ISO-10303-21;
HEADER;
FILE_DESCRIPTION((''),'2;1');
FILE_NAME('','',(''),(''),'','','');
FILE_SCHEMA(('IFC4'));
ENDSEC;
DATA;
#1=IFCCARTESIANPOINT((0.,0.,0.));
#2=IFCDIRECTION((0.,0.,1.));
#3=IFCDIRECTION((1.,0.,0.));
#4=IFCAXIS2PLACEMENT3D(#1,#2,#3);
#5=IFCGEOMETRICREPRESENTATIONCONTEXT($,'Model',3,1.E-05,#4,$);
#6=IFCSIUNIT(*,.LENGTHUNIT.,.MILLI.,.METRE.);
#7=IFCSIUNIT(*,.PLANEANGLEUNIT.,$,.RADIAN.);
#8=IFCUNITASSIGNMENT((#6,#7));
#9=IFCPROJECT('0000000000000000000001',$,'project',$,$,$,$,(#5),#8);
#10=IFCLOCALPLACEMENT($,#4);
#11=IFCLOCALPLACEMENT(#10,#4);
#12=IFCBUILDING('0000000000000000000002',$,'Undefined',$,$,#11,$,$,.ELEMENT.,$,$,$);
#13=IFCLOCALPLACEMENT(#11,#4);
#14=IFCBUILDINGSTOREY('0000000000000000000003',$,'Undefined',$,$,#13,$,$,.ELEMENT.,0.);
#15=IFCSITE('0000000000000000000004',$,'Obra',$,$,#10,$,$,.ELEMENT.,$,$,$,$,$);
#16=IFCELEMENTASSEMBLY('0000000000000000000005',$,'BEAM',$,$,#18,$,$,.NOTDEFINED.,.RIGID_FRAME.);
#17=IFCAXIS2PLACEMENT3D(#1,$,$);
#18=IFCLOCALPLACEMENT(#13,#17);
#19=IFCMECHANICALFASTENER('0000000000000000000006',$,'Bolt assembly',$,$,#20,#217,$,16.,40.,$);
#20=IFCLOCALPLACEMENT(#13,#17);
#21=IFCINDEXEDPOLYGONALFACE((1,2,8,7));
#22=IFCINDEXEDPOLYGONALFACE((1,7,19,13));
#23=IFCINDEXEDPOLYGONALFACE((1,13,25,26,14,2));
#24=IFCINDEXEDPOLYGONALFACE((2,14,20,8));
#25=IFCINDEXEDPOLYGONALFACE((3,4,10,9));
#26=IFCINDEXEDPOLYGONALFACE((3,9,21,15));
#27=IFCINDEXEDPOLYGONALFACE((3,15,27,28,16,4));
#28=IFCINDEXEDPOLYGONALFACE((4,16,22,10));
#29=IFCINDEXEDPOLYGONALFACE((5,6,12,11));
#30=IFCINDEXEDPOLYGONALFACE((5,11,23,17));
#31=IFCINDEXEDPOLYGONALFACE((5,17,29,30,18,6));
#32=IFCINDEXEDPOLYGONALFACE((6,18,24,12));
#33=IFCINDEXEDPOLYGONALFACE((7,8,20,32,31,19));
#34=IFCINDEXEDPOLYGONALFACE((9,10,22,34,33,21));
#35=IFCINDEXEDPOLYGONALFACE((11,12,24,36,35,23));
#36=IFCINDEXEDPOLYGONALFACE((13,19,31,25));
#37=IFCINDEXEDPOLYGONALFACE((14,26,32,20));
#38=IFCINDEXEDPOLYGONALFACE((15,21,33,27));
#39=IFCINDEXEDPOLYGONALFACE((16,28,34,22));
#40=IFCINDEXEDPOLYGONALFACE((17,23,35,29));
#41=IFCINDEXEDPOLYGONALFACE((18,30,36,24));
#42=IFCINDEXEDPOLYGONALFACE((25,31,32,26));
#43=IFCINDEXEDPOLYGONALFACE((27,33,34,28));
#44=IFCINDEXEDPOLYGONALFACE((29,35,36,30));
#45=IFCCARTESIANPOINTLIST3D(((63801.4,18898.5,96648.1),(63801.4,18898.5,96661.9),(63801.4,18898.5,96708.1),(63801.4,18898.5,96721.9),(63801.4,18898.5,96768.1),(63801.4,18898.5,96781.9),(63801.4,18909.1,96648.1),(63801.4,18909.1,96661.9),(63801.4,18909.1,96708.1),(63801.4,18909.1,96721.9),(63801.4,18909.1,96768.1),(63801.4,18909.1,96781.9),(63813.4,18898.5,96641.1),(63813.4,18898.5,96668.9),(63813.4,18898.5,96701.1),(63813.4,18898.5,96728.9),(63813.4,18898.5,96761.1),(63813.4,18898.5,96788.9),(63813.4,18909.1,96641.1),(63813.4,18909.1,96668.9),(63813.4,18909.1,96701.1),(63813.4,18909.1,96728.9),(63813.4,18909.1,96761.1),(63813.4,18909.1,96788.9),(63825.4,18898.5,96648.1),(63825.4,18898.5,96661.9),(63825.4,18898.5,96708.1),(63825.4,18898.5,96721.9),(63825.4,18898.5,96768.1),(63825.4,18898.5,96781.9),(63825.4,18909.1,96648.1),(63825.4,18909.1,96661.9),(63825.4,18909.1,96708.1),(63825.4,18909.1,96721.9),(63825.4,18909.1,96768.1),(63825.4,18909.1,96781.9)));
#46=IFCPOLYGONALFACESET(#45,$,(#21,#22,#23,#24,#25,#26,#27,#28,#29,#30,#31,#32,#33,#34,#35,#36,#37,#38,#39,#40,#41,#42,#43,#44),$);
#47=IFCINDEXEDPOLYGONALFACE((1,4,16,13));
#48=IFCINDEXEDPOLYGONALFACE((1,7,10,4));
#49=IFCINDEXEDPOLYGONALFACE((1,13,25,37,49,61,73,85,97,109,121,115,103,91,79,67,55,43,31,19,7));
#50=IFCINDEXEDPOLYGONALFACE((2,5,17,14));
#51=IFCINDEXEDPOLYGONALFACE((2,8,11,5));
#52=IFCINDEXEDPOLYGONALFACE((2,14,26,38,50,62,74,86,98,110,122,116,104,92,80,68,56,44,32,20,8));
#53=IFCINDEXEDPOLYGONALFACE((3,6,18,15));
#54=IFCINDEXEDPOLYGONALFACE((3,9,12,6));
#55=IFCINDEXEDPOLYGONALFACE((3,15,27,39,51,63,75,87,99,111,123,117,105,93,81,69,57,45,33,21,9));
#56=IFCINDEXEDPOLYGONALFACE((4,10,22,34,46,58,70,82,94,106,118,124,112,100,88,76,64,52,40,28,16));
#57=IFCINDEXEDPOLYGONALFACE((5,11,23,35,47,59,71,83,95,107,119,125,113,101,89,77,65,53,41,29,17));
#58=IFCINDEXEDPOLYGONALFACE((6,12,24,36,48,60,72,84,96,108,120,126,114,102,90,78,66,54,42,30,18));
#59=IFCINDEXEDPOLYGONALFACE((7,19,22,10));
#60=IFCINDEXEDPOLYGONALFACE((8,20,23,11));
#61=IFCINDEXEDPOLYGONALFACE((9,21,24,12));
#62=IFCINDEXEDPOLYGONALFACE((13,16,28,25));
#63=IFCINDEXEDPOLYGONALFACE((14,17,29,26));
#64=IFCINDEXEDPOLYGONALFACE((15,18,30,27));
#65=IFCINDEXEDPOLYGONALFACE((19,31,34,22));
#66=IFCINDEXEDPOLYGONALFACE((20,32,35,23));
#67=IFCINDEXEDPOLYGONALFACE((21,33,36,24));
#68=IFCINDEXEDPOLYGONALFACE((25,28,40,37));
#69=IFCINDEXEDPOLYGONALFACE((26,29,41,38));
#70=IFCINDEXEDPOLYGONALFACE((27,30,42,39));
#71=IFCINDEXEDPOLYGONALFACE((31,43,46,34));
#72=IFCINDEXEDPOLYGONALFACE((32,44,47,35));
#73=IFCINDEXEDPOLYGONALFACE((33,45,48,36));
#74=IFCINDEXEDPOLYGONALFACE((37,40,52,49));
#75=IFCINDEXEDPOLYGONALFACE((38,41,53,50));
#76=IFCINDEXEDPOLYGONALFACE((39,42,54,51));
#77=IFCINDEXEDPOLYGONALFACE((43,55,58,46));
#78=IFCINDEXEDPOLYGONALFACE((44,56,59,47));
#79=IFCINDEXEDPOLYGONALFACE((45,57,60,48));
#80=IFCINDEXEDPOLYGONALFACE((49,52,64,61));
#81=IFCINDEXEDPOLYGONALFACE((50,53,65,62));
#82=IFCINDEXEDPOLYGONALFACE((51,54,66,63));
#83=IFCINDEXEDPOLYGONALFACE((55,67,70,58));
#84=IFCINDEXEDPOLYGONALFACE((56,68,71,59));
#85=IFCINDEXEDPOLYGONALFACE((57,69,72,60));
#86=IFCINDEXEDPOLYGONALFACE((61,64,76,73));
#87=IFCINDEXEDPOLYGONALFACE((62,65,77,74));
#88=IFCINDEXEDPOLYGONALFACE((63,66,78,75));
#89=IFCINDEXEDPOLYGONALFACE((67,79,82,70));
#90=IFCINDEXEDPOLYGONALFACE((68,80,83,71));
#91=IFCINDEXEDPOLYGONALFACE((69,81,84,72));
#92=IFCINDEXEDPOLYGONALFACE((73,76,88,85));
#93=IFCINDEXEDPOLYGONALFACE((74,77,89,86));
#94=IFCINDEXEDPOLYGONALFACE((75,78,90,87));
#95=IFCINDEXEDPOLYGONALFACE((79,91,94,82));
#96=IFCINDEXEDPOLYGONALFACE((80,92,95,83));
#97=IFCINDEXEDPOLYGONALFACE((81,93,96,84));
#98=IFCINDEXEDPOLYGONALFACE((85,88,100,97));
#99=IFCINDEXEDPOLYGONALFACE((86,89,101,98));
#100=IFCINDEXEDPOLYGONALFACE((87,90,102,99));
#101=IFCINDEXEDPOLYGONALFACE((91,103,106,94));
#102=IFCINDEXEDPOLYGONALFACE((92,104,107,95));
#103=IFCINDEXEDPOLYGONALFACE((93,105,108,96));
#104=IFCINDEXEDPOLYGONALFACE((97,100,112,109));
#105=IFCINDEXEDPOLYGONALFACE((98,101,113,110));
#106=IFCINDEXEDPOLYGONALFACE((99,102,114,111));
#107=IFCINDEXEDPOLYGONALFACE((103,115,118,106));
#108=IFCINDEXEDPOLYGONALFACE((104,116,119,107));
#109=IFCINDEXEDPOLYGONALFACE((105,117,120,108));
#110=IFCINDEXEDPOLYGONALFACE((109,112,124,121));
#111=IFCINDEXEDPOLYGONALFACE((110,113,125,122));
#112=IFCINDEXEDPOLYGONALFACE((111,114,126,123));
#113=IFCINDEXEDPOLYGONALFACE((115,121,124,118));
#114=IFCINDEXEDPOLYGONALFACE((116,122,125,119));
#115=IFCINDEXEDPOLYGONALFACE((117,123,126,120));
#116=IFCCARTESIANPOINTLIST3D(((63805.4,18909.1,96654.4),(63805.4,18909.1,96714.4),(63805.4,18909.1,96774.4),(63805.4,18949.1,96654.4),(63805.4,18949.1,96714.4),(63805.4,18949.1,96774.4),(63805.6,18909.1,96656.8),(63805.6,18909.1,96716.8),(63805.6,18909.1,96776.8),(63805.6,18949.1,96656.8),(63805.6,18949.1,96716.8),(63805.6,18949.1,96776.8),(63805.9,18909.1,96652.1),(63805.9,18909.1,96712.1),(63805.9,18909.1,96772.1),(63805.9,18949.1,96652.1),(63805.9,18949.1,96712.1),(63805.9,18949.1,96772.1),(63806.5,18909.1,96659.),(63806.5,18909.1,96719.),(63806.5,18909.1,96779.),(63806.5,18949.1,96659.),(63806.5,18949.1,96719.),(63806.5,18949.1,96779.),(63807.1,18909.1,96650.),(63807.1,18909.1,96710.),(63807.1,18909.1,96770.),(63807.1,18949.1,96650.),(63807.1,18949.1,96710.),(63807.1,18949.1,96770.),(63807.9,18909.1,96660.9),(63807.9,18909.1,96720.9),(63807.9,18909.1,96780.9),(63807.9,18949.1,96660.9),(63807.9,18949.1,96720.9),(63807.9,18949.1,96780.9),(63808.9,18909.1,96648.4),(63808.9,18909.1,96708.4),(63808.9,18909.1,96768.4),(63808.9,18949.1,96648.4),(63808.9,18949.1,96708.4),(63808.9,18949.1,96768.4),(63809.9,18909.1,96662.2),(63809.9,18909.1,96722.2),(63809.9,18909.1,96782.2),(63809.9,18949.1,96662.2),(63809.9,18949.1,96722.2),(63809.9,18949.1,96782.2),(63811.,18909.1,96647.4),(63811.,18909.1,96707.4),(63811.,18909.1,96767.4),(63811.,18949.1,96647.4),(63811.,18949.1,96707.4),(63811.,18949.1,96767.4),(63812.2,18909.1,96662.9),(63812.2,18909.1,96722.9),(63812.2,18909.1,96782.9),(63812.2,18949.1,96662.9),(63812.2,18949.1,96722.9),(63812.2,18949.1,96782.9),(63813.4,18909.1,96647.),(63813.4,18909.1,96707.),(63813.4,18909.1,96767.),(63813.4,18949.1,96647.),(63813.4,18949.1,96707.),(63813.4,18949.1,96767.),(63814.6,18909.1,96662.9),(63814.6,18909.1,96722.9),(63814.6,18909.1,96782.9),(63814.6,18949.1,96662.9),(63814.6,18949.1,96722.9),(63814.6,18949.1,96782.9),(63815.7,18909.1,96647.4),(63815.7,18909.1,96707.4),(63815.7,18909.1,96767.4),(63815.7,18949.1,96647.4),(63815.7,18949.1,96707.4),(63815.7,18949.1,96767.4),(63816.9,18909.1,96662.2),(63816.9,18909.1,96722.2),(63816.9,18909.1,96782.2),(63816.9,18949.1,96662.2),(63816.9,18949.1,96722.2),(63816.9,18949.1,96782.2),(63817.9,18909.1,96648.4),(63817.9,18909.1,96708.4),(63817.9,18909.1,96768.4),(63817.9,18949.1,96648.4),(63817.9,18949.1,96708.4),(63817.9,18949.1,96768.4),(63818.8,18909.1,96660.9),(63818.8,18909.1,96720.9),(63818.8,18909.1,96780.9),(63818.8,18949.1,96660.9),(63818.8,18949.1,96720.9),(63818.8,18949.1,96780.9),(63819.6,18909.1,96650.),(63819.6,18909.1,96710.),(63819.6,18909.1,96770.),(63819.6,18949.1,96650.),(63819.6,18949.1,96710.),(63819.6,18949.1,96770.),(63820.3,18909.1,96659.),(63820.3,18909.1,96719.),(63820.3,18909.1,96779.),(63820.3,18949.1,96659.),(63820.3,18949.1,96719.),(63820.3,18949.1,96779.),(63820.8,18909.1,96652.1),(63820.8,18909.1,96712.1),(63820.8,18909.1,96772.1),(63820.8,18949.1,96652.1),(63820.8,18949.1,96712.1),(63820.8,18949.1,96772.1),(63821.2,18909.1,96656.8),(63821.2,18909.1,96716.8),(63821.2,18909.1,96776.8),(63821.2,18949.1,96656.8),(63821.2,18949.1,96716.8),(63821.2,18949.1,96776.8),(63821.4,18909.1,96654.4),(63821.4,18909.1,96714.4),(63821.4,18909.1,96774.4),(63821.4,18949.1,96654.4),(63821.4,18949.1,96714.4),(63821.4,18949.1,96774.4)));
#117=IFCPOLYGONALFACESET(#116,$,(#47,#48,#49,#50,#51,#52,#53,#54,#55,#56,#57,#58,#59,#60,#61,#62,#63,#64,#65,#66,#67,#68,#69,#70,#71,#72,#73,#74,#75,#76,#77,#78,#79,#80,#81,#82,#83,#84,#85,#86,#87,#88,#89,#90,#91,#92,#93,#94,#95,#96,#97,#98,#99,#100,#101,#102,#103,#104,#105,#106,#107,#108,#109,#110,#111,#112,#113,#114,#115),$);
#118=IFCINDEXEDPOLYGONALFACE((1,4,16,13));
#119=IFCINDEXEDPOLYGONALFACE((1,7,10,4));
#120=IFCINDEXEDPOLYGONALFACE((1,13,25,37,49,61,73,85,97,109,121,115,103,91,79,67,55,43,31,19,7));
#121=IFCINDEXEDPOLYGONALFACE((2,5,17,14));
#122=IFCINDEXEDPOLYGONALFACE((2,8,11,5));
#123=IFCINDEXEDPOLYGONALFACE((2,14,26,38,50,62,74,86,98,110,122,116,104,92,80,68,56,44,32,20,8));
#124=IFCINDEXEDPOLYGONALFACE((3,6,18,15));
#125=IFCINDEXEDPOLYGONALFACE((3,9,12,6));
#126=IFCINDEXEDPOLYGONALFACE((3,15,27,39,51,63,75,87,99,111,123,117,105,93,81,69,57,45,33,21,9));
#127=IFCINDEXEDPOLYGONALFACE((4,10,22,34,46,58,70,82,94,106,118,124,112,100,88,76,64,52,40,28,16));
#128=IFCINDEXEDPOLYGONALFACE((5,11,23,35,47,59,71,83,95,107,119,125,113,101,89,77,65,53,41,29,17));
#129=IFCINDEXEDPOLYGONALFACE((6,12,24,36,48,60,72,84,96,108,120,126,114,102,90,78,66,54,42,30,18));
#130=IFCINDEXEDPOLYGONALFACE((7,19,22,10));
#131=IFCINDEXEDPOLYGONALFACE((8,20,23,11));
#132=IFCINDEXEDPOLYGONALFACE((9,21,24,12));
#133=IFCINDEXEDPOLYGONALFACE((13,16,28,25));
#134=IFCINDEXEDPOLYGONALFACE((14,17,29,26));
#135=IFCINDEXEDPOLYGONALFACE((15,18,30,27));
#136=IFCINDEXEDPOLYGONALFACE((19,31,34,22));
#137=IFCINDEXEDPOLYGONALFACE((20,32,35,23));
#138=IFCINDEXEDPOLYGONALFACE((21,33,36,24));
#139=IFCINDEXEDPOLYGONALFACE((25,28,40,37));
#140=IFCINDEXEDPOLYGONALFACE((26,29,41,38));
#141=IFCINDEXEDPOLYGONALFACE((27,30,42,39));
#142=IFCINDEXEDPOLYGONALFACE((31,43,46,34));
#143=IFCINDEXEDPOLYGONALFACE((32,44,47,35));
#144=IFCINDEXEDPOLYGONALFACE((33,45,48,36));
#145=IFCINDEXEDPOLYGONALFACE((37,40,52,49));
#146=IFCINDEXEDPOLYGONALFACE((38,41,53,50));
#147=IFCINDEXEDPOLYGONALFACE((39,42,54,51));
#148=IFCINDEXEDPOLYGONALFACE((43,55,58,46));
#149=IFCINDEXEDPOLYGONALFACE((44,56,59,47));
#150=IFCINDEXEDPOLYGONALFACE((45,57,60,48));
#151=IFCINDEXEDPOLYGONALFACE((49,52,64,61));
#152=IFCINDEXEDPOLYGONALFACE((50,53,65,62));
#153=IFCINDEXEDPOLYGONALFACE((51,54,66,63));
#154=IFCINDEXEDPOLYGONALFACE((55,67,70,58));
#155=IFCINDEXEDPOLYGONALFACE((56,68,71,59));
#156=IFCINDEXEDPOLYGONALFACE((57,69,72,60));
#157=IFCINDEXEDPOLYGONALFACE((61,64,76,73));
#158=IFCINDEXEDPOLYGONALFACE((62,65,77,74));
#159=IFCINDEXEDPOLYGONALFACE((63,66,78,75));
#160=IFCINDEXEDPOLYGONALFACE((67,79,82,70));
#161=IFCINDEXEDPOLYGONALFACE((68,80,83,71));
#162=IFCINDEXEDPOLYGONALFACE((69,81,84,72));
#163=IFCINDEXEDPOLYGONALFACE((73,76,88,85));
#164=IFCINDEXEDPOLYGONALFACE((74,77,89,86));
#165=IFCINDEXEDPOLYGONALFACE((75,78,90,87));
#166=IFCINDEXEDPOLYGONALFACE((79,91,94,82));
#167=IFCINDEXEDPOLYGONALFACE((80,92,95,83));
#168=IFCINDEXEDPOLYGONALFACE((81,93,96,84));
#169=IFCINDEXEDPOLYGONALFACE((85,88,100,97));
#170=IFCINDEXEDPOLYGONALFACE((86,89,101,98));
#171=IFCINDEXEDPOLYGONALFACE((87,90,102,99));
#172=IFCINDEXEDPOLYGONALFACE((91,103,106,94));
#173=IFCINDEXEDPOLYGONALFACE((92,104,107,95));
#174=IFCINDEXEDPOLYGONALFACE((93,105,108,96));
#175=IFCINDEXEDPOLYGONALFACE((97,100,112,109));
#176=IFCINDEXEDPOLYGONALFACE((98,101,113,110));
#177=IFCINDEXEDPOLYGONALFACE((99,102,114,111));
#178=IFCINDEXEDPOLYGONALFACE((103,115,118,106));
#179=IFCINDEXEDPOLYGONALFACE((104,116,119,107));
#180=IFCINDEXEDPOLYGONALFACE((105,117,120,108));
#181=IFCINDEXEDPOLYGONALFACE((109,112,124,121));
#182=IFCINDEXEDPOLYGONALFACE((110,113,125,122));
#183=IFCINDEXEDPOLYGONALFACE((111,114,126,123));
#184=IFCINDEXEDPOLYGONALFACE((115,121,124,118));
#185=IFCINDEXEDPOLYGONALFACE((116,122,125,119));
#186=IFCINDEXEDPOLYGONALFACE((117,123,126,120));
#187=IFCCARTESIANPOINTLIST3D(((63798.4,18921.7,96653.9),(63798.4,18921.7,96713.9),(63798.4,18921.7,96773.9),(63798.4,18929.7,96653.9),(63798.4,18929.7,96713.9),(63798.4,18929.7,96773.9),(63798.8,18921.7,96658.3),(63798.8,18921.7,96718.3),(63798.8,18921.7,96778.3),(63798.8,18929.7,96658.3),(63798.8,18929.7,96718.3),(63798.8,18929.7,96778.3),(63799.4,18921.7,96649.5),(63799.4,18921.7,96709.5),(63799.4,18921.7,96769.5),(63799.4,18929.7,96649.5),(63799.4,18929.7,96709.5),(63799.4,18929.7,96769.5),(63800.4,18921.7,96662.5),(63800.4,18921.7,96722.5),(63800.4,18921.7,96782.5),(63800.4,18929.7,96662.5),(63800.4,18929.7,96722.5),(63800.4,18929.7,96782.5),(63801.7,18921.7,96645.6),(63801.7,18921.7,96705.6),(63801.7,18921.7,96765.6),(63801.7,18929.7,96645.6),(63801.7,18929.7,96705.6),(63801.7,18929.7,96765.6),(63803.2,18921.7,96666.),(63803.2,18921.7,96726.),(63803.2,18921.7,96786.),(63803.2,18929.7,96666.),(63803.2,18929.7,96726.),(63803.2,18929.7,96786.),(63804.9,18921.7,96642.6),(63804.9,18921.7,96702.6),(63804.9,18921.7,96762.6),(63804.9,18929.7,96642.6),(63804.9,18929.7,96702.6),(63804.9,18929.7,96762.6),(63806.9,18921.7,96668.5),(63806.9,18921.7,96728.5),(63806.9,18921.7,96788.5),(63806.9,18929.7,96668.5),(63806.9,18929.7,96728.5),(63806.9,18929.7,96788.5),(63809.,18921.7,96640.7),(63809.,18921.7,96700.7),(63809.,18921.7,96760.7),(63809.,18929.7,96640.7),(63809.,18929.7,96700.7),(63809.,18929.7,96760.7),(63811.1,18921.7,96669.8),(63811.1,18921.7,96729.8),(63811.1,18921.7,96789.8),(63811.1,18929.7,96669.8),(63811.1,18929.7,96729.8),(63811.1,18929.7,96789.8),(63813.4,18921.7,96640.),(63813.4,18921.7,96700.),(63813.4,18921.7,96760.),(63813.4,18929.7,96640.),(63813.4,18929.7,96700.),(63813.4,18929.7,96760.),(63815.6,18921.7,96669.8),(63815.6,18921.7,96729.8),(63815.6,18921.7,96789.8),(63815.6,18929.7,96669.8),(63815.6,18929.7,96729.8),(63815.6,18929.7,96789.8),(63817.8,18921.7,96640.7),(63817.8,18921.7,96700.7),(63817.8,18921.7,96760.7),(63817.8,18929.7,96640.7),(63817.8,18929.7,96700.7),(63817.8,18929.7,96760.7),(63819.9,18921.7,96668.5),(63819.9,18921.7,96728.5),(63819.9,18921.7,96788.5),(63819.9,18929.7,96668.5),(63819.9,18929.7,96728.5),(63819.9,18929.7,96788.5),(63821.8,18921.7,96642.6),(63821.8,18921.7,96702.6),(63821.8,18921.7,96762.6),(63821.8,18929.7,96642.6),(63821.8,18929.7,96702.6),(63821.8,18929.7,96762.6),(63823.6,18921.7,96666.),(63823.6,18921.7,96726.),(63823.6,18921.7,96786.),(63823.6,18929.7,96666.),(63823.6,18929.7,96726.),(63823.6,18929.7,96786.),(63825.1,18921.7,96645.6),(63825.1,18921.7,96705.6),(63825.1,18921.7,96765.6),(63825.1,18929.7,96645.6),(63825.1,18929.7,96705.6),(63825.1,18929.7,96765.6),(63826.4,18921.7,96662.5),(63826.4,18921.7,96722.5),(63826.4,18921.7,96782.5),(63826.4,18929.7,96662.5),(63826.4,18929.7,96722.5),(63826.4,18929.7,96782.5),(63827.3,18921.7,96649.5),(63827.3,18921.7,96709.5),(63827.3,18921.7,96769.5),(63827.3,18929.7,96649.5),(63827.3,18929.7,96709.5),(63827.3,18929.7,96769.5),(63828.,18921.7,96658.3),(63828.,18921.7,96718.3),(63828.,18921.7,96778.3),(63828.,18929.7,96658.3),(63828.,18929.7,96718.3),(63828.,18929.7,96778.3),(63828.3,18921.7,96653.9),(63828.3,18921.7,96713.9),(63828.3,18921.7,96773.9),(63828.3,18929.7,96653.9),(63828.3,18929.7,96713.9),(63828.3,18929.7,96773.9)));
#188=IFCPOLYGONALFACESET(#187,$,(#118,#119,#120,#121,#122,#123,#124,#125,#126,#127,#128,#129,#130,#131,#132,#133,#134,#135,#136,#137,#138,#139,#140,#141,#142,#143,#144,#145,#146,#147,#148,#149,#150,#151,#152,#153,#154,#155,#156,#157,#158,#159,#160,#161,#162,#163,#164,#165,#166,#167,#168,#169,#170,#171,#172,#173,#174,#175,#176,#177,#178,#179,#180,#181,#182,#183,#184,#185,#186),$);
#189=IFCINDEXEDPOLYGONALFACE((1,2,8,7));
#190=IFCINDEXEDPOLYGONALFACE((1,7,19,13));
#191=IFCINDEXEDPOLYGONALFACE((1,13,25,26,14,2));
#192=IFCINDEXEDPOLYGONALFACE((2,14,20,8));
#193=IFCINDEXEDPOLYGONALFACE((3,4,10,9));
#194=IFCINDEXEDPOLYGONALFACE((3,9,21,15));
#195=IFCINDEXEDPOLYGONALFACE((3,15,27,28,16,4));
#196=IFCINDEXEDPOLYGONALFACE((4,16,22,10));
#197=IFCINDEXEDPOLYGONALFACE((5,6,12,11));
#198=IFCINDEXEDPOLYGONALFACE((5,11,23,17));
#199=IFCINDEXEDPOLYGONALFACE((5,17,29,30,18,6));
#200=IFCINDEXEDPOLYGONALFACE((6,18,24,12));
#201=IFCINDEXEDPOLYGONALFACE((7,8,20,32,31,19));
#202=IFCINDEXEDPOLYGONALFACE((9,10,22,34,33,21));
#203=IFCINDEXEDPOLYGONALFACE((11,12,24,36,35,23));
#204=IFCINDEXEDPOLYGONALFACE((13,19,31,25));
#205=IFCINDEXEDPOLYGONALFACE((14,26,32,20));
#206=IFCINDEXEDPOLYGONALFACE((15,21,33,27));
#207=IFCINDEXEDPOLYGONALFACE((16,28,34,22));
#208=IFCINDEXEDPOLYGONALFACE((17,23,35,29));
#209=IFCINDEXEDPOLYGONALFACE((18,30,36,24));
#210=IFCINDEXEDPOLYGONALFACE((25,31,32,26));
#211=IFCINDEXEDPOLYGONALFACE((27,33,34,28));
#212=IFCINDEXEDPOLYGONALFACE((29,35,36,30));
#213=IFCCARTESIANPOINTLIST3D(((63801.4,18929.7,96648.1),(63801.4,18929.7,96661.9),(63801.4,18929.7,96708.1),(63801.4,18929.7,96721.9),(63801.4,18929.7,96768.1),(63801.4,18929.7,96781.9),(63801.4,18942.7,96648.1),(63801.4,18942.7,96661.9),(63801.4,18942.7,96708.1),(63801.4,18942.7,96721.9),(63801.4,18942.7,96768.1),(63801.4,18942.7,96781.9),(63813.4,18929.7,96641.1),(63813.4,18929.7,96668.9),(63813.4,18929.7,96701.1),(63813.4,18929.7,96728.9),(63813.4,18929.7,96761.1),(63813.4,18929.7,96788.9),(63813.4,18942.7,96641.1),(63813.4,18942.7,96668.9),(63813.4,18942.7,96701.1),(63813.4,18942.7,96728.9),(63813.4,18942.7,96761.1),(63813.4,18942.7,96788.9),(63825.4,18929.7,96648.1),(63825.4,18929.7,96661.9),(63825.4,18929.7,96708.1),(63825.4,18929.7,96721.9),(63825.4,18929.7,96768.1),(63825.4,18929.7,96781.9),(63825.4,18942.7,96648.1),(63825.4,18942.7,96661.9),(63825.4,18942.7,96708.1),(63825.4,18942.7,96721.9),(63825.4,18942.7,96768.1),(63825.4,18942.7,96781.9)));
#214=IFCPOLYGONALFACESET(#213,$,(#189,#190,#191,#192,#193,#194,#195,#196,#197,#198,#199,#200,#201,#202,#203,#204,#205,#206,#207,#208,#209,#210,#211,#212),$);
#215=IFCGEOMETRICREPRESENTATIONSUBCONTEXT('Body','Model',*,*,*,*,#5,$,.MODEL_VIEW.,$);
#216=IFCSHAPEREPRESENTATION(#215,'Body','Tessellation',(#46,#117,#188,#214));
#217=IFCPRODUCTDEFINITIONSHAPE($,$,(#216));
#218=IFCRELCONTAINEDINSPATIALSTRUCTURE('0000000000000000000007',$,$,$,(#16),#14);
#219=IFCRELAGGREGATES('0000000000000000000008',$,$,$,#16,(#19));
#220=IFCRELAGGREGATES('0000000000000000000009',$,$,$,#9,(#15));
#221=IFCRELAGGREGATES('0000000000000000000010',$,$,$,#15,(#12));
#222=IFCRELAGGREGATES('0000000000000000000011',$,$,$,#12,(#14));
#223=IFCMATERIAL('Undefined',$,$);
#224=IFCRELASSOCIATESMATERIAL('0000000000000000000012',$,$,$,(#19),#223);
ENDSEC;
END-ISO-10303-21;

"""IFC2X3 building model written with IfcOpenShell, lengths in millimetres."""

from ifc_helpers import new_model, si_unit, frame, origin_with_axes, origin_2d_with_axis, place, context, subcontext, project, spatial, polyline, circle, outline, extrude, source, transform, mapped, material, element, aggregate, save


model = new_model("IFC2X3")

# Units and contexts
model_context = context("Model", 3, precision=1e-05, world=origin_with_axes())
body_context = subcontext(model_context, "Body", "Model", "MODEL_VIEW")
ifc_project = project(units=[si_unit("LENGTHUNIT", "METRE", prefix="MILLI"), si_unit("PLANEANGLEUNIT", "RADIAN")], contexts=[model_context])

# Site, building, storey
site_placement = place(None, origin_with_axes())
site = spatial("IfcSite", under=ifc_project, at=site_placement, Name="Obra", CompositionType="ELEMENT")
building_placement = place(site_placement, origin_with_axes())
building = spatial("IfcBuilding", under=site, at=building_placement, Name="Undefined", CompositionType="ELEMENT")
storey_placement = place(building_placement, origin_with_axes())
storey = spatial("IfcBuildingStorey", under=building, at=storey_placement, Name="Undefined", CompositionType="ELEMENT", Elevation=0.0)

# Shared definitions
ifc_material_1 = material(Name="Undefined")

# Element assembly, mechanical fastener
assembly_1_placement = place(storey_placement, origin_with_axes())
assembly_1 = element("IfcElementAssembly", 1, at=assembly_1_placement, inside=storey, Name="BEAM", AssemblyPlace="NOTDEFINED", PredefinedType="RIGID_FRAME")
shared_shape_1 = source(origin_with_axes(), body_context, "Body", "SweptSolid", [
    extrude(outline(polyline([(13.9, 0.0), (6.9, 12.0), (-6.9, 12.0), (-13.9, 0.0), (-6.9, -12.0), (6.9, -12.0), (13.9, 0.0)])), frame((0.0, -19.9, 0.0), z_axis=(0.0, 1.0, 0.0), x_axis=(1.0, 0.0, 0.0)), (0.0, 0.0, 1.0), 10.6),
    extrude(circle(Radius=8.0, at=origin_2d_with_axis()), frame((0.0, -9.3, 0.0), z_axis=(0.0, 1.0, 0.0), x_axis=(1.0, 0.0, 0.0)), (0.0, 0.0, 1.0), 40.0),
    extrude(circle(Radius=15.0, at=origin_2d_with_axis()), frame((0.0, 3.3, 0.0), z_axis=(0.0, 1.0, 0.0), x_axis=(1.0, 0.0, 0.0)), (0.0, 0.0, 1.0), 8.0),
    extrude(outline(polyline([(13.9, 0.0), (6.9, 12.0), (-6.9, 12.0), (-13.9, 0.0), (-6.9, -12.0), (6.9, -12.0), (13.9, 0.0)])), frame((0.0, 11.3, 0.0), z_axis=(0.0, 1.0, 0.0), x_axis=(1.0, 0.0, 0.0)), (0.0, 0.0, 1.0), 13.0),
])
mechanical_fastener_1_placement = place(assembly_1_placement, frame((63763.4, 18918.4, 96850.0), z_axis=(1.0, 0.0, 0.0), x_axis=(0.0, 0.0, -1.0)))
mechanical_fastener_1 = element("IfcMechanicalFastener", 2, at=mechanical_fastener_1_placement, material=ifc_material_1, Name="Bolt assembly", NominalDiameter=16.0, NominalLength=40.0, context=body_context, shape_type="MappedRepresentation", body=[
    mapped(shared_shape_1, transform((75.0, 0.0, 50.0))),
    mapped(shared_shape_1, transform((135.0, 0.0, 50.0))),
    mapped(shared_shape_1, transform((195.0, 0.0, 50.0))),
])
aggregate(assembly_1, [mechanical_fastener_1])

save(model, "model.ifc")
